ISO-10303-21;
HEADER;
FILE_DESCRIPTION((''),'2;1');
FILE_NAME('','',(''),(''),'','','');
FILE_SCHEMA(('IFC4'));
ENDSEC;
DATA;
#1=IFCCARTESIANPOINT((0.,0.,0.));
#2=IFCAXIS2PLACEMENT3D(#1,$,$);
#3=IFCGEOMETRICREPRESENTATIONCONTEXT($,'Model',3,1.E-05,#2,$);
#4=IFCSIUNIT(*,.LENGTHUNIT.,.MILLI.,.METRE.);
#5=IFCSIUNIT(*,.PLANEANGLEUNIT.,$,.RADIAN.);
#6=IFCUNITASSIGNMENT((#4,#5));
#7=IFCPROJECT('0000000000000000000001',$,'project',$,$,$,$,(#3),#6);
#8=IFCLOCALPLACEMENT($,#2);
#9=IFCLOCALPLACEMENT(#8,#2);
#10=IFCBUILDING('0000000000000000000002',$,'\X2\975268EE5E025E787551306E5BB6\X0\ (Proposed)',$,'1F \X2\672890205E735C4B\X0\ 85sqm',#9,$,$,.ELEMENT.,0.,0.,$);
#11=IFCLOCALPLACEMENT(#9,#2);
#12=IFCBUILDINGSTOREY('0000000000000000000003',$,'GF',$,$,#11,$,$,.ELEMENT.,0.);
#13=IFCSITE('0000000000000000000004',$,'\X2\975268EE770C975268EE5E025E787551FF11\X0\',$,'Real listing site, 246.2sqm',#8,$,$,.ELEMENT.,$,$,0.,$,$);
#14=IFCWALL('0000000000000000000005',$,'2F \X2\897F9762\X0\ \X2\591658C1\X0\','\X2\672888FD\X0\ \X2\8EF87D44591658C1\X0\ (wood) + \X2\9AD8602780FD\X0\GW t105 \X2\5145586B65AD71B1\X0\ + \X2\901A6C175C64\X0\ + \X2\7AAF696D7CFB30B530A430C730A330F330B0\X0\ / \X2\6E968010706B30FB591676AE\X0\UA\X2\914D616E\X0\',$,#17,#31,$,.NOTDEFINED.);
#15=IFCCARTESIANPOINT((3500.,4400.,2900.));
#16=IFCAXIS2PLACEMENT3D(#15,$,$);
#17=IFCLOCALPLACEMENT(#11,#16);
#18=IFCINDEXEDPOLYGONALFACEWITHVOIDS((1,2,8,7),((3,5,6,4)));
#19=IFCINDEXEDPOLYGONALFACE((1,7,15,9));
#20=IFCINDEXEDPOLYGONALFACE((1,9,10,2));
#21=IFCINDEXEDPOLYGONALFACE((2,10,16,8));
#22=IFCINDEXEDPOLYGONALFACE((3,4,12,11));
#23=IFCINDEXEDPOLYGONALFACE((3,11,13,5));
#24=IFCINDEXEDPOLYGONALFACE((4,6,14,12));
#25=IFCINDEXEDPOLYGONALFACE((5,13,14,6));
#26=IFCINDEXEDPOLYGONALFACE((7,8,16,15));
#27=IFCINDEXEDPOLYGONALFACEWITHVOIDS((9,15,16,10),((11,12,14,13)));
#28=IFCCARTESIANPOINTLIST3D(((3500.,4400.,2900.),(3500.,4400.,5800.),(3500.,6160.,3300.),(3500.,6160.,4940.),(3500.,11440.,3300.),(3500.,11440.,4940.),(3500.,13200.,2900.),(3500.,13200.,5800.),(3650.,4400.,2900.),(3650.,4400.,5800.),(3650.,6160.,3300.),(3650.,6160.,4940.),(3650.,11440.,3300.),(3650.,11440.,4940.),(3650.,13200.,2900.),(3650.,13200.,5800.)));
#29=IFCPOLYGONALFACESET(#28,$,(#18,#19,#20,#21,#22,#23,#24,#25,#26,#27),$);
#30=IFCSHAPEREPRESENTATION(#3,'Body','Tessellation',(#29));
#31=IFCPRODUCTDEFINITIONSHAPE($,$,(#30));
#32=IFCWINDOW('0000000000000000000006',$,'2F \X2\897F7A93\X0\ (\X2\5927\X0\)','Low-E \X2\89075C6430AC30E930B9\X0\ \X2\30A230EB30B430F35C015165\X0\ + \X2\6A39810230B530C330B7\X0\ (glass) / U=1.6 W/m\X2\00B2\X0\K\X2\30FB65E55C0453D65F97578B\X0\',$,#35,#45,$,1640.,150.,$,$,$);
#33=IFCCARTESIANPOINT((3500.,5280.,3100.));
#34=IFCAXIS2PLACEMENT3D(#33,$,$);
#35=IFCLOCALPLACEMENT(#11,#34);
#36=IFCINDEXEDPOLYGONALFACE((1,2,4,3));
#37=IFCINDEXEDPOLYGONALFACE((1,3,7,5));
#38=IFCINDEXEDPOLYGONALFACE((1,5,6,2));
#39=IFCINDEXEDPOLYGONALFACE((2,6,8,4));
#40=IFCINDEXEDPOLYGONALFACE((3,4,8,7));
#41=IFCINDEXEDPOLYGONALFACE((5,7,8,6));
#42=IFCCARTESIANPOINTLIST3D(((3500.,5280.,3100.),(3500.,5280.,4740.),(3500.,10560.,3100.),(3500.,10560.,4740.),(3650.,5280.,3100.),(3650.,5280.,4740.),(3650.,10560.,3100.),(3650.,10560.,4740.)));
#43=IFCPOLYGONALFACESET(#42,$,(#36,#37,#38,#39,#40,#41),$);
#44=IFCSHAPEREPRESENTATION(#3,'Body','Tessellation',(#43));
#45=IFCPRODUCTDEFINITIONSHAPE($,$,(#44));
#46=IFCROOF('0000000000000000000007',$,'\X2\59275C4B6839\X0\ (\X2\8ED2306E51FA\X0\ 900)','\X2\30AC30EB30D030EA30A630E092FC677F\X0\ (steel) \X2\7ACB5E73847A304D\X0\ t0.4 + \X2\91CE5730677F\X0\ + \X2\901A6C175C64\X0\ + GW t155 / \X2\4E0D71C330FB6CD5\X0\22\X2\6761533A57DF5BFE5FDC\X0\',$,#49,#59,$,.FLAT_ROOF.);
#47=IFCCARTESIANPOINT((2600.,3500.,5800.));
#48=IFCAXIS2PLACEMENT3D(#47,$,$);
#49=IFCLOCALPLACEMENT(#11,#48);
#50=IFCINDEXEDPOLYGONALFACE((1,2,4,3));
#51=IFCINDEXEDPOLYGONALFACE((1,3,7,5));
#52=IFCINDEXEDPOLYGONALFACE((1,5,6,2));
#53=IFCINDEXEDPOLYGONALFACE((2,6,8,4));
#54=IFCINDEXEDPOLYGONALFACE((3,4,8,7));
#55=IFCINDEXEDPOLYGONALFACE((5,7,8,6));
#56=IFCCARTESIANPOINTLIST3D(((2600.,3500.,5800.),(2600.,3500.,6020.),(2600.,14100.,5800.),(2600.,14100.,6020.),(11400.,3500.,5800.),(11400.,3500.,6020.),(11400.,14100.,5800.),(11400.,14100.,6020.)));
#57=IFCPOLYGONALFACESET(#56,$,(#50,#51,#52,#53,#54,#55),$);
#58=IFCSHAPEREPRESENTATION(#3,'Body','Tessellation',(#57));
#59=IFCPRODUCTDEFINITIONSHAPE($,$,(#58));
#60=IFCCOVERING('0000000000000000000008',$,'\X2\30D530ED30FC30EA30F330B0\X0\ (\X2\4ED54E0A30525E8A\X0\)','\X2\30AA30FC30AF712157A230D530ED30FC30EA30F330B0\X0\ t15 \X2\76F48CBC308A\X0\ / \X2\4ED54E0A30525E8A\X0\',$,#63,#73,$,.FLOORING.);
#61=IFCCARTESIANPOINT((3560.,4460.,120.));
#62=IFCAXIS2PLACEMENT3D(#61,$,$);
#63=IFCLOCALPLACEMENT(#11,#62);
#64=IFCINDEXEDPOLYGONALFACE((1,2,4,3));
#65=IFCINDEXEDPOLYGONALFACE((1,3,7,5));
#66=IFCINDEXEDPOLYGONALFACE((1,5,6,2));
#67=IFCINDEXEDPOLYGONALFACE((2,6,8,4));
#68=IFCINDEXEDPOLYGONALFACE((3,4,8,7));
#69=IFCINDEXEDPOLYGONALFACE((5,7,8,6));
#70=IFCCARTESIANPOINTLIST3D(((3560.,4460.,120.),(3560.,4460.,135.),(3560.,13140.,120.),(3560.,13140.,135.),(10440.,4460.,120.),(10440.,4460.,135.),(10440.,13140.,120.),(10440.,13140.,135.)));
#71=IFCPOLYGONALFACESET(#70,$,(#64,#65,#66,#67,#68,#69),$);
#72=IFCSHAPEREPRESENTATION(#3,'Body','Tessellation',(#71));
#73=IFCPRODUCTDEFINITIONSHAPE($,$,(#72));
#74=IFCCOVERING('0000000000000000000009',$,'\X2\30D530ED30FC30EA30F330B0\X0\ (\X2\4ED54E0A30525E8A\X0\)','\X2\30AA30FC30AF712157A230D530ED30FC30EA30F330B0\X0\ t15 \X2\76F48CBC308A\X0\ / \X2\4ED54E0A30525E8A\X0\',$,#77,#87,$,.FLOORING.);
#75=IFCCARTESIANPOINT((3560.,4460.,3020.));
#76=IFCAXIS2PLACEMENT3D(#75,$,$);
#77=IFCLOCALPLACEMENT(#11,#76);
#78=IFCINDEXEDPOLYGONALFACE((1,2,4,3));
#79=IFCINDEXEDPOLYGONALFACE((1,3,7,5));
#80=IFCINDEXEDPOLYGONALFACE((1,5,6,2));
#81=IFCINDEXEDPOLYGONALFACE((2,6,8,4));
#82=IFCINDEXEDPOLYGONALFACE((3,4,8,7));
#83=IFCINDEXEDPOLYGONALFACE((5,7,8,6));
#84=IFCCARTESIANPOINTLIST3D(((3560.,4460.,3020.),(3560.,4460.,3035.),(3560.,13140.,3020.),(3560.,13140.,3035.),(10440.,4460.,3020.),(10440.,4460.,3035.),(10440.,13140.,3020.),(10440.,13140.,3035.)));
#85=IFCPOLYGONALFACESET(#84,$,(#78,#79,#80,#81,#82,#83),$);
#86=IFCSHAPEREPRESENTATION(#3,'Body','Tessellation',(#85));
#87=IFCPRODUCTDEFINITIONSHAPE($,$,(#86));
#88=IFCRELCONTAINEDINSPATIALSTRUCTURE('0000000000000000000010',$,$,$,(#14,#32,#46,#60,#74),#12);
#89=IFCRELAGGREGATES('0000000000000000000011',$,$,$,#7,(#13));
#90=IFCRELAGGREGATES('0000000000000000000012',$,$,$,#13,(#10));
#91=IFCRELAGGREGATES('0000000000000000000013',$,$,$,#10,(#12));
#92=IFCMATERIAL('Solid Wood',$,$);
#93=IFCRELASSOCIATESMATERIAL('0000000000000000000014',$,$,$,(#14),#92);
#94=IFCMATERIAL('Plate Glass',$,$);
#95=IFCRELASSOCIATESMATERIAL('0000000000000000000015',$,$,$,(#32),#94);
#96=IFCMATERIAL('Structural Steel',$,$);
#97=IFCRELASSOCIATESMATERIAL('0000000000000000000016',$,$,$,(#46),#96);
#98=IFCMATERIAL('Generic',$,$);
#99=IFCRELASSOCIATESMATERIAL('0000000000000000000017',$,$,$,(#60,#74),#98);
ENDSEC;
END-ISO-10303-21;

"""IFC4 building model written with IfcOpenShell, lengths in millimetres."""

from ifc_helpers import new_model, si_unit, frame, frame_2d, origin, place, context, project, spatial, rectangle, extrude, material, element, fill, save


model = new_model("IFC4")

# Units and contexts
model_context = context("Model", 3, precision=1e-05, world=origin())
ifc_project = project(units=[si_unit("LENGTHUNIT", "METRE", prefix="MILLI"), si_unit("PLANEANGLEUNIT", "RADIAN")], contexts=[model_context])

# Site, building, storey
site_placement = place(None, origin())
site = spatial("IfcSite", under=ifc_project, at=site_placement, Name="青森県青森市幸畑１", ObjectType="Real listing site, 246.2sqm", CompositionType="ELEMENT", RefElevation=0.0)
building_placement = place(site_placement, origin())
building = spatial("IfcBuilding", under=site, at=building_placement, Name="青森市幸畑の家 (Proposed)", ObjectType="1F 木造平屋 85sqm", CompositionType="ELEMENT", ElevationOfRefHeight=0.0, ElevationOfTerrain=0.0)
storey_placement = place(building_placement, origin())
storey = spatial("IfcBuildingStorey", under=building, at=storey_placement, Name="GF", CompositionType="ELEMENT", Elevation=0.0)

# Shared definitions
ifc_material_1 = material(Name="Solid Wood")
ifc_material_2 = material(Name="Generic")

# Shared definitions
ifc_material_3 = material(Name="Plate Glass")

# Wall, opening, window
wall_1_placement = place(storey_placement, frame((3500.0, 4400.0, 2900.0)))
wall_1 = element("IfcWall", 1, at=wall_1_placement, inside=storey, material=ifc_material_1, Name="2F 西面 外壁", Description="木製 軸組外壁 (wood) + 高性能GW t105 充填断熱 + 通気層 + 窯業系サイディング / 準耐火・外皮UA配慮", PredefinedType="NOTDEFINED", context=model_context, shape_type="SweptSolid", body=[
    extrude(rectangle(XDim=150.0, YDim=8800.0, at=frame_2d((75.0, 4400.0))), frame((3500.0, 4400.0, 2900.0)), (0.0, 0.0, 1.0), 2900.0),
])
opening_1_placement = place(storey_placement, frame((3500.0, 5280.0, 3100.0)))
opening_1 = element("IfcOpeningElement", 2, at=opening_1_placement, cuts=wall_1, PredefinedType="NOTDEFINED", context=model_context, shape_type="SweptSolid", body=[
    extrude(rectangle(XDim=150.0, YDim=5280.0, at=frame_2d((75.0, 2640.0))), frame((3500.0, 5280.0, 3100.0)), (0.0, 0.0, 1.0), 1640.0),
])
window_1_placement = place(storey_placement, frame((3500.0, 5280.0, 3100.0)))
window_1 = element("IfcWindow", 3, at=window_1_placement, inside=storey, material=ifc_material_3, Name="2F 西窓 (大)", Description="Low-E 複層ガラス アルゴン封入 + 樹脂サッシ (glass) / U=1.6 W/m²K・日射取得型", OverallHeight=1640.0, OverallWidth=150.0, context=model_context, shape_type="SweptSolid", body=[
    extrude(rectangle(XDim=150.0, YDim=5280.0, at=frame_2d((75.0, 2640.0))), frame((3500.0, 5280.0, 3100.0)), (0.0, 0.0, 1.0), 1640.0),
])
fill(opening_1, window_1)

# Roof
ifc_material_4 = material(Name="Structural Steel")
roof_placement = place(storey_placement, frame((2600.0, 3500.0, 5800.0)))
element("IfcRoof", 4, at=roof_placement, inside=storey, material=ifc_material_4, Name="大屋根 (軒の出 900)", Description="ガルバリウム鋼板 (steel) 立平葺き t0.4 + 野地板 + 通気層 + GW t155 / 不燃・法22条区域対応", PredefinedType="FLAT_ROOF", context=model_context, shape_type="SweptSolid", body=[
    extrude(rectangle(XDim=8800.0, YDim=10600.0, at=frame_2d((4400.0, 5300.0))), frame((2600.0, 3500.0, 5800.0)), (0.0, 0.0, 1.0), 220.0),
])

# Coverings
covering_1_placement = place(storey_placement, frame((3560.0, 4460.0, 120.0)))
element("IfcCovering", 5, at=covering_1_placement, inside=storey, material=ifc_material_2, Name="フローリング (仕上げ床)", Description="オーク無垢フローリング t15 直貼り / 仕上げ床", PredefinedType="FLOORING", context=model_context, shape_type="SweptSolid", body=[
    extrude(rectangle(XDim=6880.0, YDim=8680.0, at=frame_2d((3440.0, 4340.0))), frame((3560.0, 4460.0, 120.0)), (0.0, 0.0, 1.0), 15.0),
])
covering_2_placement = place(storey_placement, frame((3560.0, 4460.0, 3020.0)))
element("IfcCovering", 6, at=covering_2_placement, inside=storey, material=ifc_material_2, Name="フローリング (仕上げ床)", Description="オーク無垢フローリング t15 直貼り / 仕上げ床", PredefinedType="FLOORING", context=model_context, shape_type="SweptSolid", body=[
    extrude(rectangle(XDim=6880.0, YDim=8680.0, at=frame_2d((3440.0, 4340.0))), frame((3560.0, 4460.0, 3020.0)), (0.0, 0.0, 1.0), 15.0),
])

save(model, "model.ifc")
